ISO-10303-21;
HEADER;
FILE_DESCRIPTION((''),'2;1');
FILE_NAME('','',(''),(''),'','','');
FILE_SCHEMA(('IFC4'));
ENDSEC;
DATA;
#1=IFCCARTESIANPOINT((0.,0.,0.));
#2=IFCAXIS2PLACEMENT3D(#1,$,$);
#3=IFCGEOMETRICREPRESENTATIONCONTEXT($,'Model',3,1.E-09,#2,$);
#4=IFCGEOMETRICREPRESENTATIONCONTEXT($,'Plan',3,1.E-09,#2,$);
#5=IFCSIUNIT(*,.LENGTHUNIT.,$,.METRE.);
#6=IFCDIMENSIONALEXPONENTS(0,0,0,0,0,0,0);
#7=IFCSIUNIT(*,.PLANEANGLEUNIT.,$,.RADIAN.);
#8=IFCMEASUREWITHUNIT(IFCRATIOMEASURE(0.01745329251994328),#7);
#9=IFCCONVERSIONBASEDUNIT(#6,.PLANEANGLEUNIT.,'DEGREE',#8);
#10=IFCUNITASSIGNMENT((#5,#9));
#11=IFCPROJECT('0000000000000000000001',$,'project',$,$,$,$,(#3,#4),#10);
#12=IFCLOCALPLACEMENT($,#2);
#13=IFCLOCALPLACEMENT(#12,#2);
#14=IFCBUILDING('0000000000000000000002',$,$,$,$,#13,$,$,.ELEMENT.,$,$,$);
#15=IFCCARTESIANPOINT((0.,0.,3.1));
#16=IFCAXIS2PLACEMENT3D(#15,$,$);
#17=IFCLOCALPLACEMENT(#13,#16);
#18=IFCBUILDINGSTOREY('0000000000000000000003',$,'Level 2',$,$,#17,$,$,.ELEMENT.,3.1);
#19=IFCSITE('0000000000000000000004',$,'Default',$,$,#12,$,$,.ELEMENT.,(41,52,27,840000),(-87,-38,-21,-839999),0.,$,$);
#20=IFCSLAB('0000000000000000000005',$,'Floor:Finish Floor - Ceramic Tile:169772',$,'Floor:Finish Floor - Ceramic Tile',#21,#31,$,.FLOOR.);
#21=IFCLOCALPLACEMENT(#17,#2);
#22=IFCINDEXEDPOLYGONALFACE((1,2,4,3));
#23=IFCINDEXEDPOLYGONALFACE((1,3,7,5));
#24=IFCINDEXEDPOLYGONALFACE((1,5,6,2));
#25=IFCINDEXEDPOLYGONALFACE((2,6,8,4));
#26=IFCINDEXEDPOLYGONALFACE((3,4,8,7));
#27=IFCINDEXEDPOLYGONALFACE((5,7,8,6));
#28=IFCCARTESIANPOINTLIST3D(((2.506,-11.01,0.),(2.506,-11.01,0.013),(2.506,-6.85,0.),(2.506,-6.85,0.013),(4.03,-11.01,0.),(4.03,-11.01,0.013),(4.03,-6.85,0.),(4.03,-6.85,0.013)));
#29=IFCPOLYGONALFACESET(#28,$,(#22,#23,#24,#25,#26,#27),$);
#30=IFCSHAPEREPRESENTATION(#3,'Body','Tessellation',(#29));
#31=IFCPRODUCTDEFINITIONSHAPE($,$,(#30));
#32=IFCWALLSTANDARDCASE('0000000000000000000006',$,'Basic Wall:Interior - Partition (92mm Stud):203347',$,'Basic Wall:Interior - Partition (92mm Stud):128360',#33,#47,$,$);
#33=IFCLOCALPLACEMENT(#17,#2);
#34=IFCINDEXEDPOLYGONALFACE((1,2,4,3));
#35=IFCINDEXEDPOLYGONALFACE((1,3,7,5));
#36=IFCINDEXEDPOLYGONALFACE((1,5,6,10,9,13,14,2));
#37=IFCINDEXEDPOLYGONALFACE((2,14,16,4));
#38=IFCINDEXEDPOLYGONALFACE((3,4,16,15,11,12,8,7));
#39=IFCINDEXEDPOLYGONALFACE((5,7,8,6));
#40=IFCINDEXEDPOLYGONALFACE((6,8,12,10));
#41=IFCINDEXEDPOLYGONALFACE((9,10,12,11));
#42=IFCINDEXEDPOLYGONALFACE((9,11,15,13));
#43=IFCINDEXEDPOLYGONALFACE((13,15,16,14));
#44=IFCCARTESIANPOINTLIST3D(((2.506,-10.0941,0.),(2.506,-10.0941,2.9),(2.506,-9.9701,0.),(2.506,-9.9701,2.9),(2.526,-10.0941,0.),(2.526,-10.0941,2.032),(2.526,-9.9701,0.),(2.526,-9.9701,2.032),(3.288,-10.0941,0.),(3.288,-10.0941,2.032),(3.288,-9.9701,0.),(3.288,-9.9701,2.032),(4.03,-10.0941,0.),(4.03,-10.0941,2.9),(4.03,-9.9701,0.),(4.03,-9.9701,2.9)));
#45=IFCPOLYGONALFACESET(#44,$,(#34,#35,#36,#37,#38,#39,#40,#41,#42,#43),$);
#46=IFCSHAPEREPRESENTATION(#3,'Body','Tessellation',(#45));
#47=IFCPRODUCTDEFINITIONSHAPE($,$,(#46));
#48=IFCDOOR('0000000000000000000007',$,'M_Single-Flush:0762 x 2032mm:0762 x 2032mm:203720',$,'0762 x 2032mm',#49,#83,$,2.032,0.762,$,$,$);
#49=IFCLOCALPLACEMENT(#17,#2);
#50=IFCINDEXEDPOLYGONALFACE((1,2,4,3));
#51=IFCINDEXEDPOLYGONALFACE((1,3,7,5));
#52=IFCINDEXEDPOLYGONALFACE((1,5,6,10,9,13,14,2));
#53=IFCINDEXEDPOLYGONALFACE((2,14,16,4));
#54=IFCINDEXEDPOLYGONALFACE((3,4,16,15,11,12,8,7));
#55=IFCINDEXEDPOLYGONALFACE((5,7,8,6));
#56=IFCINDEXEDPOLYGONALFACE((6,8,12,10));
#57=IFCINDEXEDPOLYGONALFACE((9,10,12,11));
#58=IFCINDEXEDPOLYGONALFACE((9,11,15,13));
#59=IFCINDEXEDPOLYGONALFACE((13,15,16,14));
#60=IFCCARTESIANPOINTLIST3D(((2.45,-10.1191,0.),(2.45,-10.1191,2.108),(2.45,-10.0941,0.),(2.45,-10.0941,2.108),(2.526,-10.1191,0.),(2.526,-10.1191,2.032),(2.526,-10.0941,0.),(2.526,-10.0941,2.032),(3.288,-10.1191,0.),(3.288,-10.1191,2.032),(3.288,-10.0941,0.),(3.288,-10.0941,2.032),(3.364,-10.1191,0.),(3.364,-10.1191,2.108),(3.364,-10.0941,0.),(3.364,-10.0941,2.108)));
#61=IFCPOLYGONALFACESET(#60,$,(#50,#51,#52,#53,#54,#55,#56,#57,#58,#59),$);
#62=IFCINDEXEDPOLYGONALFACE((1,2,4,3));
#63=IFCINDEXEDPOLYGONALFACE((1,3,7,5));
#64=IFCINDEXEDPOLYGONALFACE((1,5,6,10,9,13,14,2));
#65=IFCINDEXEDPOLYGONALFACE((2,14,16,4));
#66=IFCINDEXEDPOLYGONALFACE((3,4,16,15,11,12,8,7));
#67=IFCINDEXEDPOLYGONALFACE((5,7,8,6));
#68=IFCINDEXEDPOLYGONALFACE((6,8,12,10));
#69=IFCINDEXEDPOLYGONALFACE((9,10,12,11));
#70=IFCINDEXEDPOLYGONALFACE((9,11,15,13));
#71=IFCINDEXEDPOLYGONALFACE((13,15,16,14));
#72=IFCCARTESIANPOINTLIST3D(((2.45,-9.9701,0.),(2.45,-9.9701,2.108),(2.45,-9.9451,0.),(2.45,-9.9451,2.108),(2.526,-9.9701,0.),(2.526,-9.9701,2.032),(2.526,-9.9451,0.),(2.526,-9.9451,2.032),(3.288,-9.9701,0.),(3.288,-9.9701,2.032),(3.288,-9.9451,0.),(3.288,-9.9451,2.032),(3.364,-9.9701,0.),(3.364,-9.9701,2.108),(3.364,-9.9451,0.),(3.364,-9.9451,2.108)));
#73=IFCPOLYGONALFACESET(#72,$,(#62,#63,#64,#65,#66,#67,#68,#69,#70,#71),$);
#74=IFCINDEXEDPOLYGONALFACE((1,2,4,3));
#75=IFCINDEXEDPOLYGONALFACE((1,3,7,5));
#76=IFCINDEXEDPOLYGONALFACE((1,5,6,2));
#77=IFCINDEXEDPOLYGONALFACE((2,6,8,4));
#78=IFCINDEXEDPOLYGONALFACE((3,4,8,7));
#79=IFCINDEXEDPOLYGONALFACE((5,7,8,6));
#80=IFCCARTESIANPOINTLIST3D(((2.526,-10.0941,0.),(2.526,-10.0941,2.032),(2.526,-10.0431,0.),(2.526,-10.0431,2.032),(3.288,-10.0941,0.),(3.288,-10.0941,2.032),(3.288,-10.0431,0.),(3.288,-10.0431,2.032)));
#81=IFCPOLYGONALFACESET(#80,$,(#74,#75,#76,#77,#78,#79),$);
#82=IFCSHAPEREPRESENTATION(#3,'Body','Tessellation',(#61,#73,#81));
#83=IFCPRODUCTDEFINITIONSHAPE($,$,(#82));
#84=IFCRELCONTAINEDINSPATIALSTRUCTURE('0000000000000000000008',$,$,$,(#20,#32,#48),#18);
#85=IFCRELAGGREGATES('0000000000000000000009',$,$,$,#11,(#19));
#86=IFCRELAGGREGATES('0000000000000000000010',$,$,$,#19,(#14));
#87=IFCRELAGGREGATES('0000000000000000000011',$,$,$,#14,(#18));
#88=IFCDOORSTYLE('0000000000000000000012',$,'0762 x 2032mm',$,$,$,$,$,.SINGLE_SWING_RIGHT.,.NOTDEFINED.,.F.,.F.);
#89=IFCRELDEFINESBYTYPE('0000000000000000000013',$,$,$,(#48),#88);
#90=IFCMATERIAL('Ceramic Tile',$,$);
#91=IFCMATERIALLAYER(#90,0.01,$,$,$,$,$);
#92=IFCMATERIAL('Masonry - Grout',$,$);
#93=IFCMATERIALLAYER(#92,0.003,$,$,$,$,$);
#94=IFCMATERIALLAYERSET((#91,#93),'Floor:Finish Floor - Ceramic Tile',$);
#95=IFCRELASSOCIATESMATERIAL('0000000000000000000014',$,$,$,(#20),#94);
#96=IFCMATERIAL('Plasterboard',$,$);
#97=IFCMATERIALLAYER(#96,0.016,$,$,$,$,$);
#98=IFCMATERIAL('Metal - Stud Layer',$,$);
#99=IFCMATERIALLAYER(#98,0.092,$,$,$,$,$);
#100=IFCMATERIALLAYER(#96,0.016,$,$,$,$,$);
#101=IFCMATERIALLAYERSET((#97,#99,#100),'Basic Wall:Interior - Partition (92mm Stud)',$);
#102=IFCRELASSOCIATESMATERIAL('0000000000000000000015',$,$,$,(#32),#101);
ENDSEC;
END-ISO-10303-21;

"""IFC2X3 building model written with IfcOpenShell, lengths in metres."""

from ifc_helpers import new_model, entity, si_unit, converted_unit, frame, frame_2d, origin, origin_2d_with_axis, place, context, project, spatial, polyline, rectangle, outline, extrude, source, transform, mapped, material, layer, layer_set, layer_usage, type_object, type_shapes, element, fill, save


model = new_model("IFC2X3")

# Units and contexts
model_context = context("Model", 3, precision=1e-09, world=origin())
plan_context = context("Plan", 3, precision=1e-09, world=origin())
ifc_project = project(units=[si_unit("LENGTHUNIT", "METRE"), converted_unit("PLANEANGLEUNIT", "DEGREE", entity("IfcRatioMeasure", 0.01745329251994328), si_unit("PLANEANGLEUNIT", "RADIAN"), dimensions=[0, 0, 0, 0, 0, 0, 0])], contexts=[model_context, plan_context])

# Site, building, storey
site_placement = place(None, origin())
site = spatial("IfcSite", under=ifc_project, at=site_placement, Name="Default", CompositionType="ELEMENT", RefLatitude=(41, 52, 27, 840000), RefLongitude=(-87, -38, -21, -839999), RefElevation=0.0)
building_placement = place(site_placement, origin())
building = spatial("IfcBuilding", under=site, at=building_placement, CompositionType="ELEMENT")
storey_placement = place(building_placement, frame((0.0, 0.0, 3.1)))
storey = spatial("IfcBuildingStorey", under=building, at=storey_placement, Name="Level 2", CompositionType="ELEMENT", Elevation=3.1)

# Slab
ifc_material_1 = material(Name="Ceramic Tile")
ifc_layer_1 = layer(ifc_material_1, 0.01)
ifc_material_2 = material(Name="Masonry - Grout")
ifc_layer_2 = layer(ifc_material_2, 0.003)
ifc_layer_set_1 = layer_set([ifc_layer_1, ifc_layer_2], Name="Floor:Finish Floor - Ceramic Tile")
ifc_layer_usage_1 = layer_usage(ifc_layer_set_1, "AXIS3", "POSITIVE", 0.0)
slab_placement = place(storey_placement, frame((2.506, -11.01, 0.0)))
element("IfcSlab", 1, at=slab_placement, inside=storey, material=ifc_layer_usage_1, Name="Floor:Finish Floor - Ceramic Tile:169772", ObjectType="Floor:Finish Floor - Ceramic Tile", PredefinedType="FLOOR", context=model_context, shape_type="SweptSolid", body=[
    extrude(rectangle(XDim=4.16, YDim=1.524, at=frame_2d((0.0, 0.0), x_axis=(0.0, -1.0))), frame((0.762, 2.08, 0.013), z_axis=(0.0, 0.0, -1.0), x_axis=(-1.0, 0.0, 0.0)), (0.0, 0.0, 1.0), 0.013),
])

# Wall, opening, door
ifc_material_3 = material(Name="Plasterboard")
ifc_layer_3 = layer(ifc_material_3, 0.016)
ifc_material_4 = material(Name="Metal - Stud Layer")
ifc_layer_4 = layer(ifc_material_4, 0.092)
ifc_layer_5 = layer(ifc_material_3, 0.016)
ifc_layer_set_2 = layer_set([ifc_layer_3, ifc_layer_4, ifc_layer_5], Name="Basic Wall:Interior - Partition (92mm Stud)")
ifc_layer_usage_2 = layer_usage(ifc_layer_set_2, "AXIS2", "NEGATIVE", 0.062)
wall_placement = place(storey_placement, frame((4.03, -10.0321, 0.0), z_axis=(0.0, 0.0, 1.0), x_axis=(-1.0, 0.0, 0.0)))
wall = element("IfcWallStandardCase", 2, at=wall_placement, inside=storey, material=ifc_layer_usage_2, Name="Basic Wall:Interior - Partition (92mm Stud):203347", ObjectType="Basic Wall:Interior - Partition (92mm Stud):128360", context=model_context, shape_type="SweptSolid", body=[
    extrude(rectangle(XDim=1.524, YDim=0.124, at=frame_2d((0.762, 0.0), x_axis=(-1.0, 0.0))), origin(), (0.0, 0.0, 1.0), 2.9),
])
opening_placement = place(wall_placement, frame((0.742, -0.062, 0.0)))
opening = element("IfcOpeningElement", 3, at=opening_placement, cuts=wall, ObjectType="Opening", context=model_context, shape_type="SweptSolid", body=[
    extrude(rectangle(XDim=0.762, YDim=2.032, at=frame_2d((1.016, 0.381), x_axis=(0.0, 1.0))), frame((0.0, 0.0, 0.0), z_axis=(0.0, 1.0, 0.0), x_axis=(0.0, 0.0, 1.0)), (0.0, 0.0, 1.0), 0.124),
])
door_style = type_object("IfcDoorStyle", Name="0762 x 2032mm", ConstructionType="NOTDEFINED", OperationType="SINGLE_SWING_RIGHT", ParameterTakesPrecedence=False, Sizeable=False)
shared_shape = source(origin(), model_context, "Body", "SweptSolid", [
    extrude(outline(polyline([(-0.457, -1.073), (0.457, -1.073), (0.457, 1.035), (0.381, 1.035), (0.381, -0.997), (-0.381, -0.997), (-0.381, 1.035), (-0.457, 1.035), (-0.457, -1.073)])), frame((0.381, 0.124, 1.035), z_axis=(0.0, 1.0, 0.0), x_axis=(1.0, 0.0, 0.0)), (0.0, 0.0, 1.0), 0.025),
    extrude(outline(polyline([(-1.073, -0.457), (1.035, -0.457), (1.035, -0.381), (-0.997, -0.381), (-0.997, 0.381), (1.035, 0.381), (1.035, 0.457), (-1.073, 0.457), (-1.073, -0.457)])), frame((0.381, -0.025, 1.035), z_axis=(0.0, 1.0, 0.0), x_axis=(0.0, 0.0, -1.0)), (0.0, 0.0, 1.0), 0.025),
    extrude(rectangle(XDim=0.051, YDim=0.762, at=origin_2d_with_axis()), frame((0.381, 0.0985, 0.0), z_axis=(0.0, 0.0, 1.0), x_axis=(0.0, 1.0, 0.0)), (0.0, 0.0, 1.0), 2.032),
])
type_shapes(door_style, [shared_shape])
door_placement = place(opening_placement, origin())
door = element("IfcDoor", 4, at=door_placement, inside=storey, type_object=door_style, Name="M_Single-Flush:0762 x 2032mm:0762 x 2032mm:203720", ObjectType="0762 x 2032mm", OverallHeight=2.032, OverallWidth=0.762, context=model_context, shape_type="MappedRepresentation", body=[
    mapped(shared_shape, transform((0.0, 0.0, 0.0), scale=1.0)),
])
fill(opening, door)

save(model, "model.ifc")
